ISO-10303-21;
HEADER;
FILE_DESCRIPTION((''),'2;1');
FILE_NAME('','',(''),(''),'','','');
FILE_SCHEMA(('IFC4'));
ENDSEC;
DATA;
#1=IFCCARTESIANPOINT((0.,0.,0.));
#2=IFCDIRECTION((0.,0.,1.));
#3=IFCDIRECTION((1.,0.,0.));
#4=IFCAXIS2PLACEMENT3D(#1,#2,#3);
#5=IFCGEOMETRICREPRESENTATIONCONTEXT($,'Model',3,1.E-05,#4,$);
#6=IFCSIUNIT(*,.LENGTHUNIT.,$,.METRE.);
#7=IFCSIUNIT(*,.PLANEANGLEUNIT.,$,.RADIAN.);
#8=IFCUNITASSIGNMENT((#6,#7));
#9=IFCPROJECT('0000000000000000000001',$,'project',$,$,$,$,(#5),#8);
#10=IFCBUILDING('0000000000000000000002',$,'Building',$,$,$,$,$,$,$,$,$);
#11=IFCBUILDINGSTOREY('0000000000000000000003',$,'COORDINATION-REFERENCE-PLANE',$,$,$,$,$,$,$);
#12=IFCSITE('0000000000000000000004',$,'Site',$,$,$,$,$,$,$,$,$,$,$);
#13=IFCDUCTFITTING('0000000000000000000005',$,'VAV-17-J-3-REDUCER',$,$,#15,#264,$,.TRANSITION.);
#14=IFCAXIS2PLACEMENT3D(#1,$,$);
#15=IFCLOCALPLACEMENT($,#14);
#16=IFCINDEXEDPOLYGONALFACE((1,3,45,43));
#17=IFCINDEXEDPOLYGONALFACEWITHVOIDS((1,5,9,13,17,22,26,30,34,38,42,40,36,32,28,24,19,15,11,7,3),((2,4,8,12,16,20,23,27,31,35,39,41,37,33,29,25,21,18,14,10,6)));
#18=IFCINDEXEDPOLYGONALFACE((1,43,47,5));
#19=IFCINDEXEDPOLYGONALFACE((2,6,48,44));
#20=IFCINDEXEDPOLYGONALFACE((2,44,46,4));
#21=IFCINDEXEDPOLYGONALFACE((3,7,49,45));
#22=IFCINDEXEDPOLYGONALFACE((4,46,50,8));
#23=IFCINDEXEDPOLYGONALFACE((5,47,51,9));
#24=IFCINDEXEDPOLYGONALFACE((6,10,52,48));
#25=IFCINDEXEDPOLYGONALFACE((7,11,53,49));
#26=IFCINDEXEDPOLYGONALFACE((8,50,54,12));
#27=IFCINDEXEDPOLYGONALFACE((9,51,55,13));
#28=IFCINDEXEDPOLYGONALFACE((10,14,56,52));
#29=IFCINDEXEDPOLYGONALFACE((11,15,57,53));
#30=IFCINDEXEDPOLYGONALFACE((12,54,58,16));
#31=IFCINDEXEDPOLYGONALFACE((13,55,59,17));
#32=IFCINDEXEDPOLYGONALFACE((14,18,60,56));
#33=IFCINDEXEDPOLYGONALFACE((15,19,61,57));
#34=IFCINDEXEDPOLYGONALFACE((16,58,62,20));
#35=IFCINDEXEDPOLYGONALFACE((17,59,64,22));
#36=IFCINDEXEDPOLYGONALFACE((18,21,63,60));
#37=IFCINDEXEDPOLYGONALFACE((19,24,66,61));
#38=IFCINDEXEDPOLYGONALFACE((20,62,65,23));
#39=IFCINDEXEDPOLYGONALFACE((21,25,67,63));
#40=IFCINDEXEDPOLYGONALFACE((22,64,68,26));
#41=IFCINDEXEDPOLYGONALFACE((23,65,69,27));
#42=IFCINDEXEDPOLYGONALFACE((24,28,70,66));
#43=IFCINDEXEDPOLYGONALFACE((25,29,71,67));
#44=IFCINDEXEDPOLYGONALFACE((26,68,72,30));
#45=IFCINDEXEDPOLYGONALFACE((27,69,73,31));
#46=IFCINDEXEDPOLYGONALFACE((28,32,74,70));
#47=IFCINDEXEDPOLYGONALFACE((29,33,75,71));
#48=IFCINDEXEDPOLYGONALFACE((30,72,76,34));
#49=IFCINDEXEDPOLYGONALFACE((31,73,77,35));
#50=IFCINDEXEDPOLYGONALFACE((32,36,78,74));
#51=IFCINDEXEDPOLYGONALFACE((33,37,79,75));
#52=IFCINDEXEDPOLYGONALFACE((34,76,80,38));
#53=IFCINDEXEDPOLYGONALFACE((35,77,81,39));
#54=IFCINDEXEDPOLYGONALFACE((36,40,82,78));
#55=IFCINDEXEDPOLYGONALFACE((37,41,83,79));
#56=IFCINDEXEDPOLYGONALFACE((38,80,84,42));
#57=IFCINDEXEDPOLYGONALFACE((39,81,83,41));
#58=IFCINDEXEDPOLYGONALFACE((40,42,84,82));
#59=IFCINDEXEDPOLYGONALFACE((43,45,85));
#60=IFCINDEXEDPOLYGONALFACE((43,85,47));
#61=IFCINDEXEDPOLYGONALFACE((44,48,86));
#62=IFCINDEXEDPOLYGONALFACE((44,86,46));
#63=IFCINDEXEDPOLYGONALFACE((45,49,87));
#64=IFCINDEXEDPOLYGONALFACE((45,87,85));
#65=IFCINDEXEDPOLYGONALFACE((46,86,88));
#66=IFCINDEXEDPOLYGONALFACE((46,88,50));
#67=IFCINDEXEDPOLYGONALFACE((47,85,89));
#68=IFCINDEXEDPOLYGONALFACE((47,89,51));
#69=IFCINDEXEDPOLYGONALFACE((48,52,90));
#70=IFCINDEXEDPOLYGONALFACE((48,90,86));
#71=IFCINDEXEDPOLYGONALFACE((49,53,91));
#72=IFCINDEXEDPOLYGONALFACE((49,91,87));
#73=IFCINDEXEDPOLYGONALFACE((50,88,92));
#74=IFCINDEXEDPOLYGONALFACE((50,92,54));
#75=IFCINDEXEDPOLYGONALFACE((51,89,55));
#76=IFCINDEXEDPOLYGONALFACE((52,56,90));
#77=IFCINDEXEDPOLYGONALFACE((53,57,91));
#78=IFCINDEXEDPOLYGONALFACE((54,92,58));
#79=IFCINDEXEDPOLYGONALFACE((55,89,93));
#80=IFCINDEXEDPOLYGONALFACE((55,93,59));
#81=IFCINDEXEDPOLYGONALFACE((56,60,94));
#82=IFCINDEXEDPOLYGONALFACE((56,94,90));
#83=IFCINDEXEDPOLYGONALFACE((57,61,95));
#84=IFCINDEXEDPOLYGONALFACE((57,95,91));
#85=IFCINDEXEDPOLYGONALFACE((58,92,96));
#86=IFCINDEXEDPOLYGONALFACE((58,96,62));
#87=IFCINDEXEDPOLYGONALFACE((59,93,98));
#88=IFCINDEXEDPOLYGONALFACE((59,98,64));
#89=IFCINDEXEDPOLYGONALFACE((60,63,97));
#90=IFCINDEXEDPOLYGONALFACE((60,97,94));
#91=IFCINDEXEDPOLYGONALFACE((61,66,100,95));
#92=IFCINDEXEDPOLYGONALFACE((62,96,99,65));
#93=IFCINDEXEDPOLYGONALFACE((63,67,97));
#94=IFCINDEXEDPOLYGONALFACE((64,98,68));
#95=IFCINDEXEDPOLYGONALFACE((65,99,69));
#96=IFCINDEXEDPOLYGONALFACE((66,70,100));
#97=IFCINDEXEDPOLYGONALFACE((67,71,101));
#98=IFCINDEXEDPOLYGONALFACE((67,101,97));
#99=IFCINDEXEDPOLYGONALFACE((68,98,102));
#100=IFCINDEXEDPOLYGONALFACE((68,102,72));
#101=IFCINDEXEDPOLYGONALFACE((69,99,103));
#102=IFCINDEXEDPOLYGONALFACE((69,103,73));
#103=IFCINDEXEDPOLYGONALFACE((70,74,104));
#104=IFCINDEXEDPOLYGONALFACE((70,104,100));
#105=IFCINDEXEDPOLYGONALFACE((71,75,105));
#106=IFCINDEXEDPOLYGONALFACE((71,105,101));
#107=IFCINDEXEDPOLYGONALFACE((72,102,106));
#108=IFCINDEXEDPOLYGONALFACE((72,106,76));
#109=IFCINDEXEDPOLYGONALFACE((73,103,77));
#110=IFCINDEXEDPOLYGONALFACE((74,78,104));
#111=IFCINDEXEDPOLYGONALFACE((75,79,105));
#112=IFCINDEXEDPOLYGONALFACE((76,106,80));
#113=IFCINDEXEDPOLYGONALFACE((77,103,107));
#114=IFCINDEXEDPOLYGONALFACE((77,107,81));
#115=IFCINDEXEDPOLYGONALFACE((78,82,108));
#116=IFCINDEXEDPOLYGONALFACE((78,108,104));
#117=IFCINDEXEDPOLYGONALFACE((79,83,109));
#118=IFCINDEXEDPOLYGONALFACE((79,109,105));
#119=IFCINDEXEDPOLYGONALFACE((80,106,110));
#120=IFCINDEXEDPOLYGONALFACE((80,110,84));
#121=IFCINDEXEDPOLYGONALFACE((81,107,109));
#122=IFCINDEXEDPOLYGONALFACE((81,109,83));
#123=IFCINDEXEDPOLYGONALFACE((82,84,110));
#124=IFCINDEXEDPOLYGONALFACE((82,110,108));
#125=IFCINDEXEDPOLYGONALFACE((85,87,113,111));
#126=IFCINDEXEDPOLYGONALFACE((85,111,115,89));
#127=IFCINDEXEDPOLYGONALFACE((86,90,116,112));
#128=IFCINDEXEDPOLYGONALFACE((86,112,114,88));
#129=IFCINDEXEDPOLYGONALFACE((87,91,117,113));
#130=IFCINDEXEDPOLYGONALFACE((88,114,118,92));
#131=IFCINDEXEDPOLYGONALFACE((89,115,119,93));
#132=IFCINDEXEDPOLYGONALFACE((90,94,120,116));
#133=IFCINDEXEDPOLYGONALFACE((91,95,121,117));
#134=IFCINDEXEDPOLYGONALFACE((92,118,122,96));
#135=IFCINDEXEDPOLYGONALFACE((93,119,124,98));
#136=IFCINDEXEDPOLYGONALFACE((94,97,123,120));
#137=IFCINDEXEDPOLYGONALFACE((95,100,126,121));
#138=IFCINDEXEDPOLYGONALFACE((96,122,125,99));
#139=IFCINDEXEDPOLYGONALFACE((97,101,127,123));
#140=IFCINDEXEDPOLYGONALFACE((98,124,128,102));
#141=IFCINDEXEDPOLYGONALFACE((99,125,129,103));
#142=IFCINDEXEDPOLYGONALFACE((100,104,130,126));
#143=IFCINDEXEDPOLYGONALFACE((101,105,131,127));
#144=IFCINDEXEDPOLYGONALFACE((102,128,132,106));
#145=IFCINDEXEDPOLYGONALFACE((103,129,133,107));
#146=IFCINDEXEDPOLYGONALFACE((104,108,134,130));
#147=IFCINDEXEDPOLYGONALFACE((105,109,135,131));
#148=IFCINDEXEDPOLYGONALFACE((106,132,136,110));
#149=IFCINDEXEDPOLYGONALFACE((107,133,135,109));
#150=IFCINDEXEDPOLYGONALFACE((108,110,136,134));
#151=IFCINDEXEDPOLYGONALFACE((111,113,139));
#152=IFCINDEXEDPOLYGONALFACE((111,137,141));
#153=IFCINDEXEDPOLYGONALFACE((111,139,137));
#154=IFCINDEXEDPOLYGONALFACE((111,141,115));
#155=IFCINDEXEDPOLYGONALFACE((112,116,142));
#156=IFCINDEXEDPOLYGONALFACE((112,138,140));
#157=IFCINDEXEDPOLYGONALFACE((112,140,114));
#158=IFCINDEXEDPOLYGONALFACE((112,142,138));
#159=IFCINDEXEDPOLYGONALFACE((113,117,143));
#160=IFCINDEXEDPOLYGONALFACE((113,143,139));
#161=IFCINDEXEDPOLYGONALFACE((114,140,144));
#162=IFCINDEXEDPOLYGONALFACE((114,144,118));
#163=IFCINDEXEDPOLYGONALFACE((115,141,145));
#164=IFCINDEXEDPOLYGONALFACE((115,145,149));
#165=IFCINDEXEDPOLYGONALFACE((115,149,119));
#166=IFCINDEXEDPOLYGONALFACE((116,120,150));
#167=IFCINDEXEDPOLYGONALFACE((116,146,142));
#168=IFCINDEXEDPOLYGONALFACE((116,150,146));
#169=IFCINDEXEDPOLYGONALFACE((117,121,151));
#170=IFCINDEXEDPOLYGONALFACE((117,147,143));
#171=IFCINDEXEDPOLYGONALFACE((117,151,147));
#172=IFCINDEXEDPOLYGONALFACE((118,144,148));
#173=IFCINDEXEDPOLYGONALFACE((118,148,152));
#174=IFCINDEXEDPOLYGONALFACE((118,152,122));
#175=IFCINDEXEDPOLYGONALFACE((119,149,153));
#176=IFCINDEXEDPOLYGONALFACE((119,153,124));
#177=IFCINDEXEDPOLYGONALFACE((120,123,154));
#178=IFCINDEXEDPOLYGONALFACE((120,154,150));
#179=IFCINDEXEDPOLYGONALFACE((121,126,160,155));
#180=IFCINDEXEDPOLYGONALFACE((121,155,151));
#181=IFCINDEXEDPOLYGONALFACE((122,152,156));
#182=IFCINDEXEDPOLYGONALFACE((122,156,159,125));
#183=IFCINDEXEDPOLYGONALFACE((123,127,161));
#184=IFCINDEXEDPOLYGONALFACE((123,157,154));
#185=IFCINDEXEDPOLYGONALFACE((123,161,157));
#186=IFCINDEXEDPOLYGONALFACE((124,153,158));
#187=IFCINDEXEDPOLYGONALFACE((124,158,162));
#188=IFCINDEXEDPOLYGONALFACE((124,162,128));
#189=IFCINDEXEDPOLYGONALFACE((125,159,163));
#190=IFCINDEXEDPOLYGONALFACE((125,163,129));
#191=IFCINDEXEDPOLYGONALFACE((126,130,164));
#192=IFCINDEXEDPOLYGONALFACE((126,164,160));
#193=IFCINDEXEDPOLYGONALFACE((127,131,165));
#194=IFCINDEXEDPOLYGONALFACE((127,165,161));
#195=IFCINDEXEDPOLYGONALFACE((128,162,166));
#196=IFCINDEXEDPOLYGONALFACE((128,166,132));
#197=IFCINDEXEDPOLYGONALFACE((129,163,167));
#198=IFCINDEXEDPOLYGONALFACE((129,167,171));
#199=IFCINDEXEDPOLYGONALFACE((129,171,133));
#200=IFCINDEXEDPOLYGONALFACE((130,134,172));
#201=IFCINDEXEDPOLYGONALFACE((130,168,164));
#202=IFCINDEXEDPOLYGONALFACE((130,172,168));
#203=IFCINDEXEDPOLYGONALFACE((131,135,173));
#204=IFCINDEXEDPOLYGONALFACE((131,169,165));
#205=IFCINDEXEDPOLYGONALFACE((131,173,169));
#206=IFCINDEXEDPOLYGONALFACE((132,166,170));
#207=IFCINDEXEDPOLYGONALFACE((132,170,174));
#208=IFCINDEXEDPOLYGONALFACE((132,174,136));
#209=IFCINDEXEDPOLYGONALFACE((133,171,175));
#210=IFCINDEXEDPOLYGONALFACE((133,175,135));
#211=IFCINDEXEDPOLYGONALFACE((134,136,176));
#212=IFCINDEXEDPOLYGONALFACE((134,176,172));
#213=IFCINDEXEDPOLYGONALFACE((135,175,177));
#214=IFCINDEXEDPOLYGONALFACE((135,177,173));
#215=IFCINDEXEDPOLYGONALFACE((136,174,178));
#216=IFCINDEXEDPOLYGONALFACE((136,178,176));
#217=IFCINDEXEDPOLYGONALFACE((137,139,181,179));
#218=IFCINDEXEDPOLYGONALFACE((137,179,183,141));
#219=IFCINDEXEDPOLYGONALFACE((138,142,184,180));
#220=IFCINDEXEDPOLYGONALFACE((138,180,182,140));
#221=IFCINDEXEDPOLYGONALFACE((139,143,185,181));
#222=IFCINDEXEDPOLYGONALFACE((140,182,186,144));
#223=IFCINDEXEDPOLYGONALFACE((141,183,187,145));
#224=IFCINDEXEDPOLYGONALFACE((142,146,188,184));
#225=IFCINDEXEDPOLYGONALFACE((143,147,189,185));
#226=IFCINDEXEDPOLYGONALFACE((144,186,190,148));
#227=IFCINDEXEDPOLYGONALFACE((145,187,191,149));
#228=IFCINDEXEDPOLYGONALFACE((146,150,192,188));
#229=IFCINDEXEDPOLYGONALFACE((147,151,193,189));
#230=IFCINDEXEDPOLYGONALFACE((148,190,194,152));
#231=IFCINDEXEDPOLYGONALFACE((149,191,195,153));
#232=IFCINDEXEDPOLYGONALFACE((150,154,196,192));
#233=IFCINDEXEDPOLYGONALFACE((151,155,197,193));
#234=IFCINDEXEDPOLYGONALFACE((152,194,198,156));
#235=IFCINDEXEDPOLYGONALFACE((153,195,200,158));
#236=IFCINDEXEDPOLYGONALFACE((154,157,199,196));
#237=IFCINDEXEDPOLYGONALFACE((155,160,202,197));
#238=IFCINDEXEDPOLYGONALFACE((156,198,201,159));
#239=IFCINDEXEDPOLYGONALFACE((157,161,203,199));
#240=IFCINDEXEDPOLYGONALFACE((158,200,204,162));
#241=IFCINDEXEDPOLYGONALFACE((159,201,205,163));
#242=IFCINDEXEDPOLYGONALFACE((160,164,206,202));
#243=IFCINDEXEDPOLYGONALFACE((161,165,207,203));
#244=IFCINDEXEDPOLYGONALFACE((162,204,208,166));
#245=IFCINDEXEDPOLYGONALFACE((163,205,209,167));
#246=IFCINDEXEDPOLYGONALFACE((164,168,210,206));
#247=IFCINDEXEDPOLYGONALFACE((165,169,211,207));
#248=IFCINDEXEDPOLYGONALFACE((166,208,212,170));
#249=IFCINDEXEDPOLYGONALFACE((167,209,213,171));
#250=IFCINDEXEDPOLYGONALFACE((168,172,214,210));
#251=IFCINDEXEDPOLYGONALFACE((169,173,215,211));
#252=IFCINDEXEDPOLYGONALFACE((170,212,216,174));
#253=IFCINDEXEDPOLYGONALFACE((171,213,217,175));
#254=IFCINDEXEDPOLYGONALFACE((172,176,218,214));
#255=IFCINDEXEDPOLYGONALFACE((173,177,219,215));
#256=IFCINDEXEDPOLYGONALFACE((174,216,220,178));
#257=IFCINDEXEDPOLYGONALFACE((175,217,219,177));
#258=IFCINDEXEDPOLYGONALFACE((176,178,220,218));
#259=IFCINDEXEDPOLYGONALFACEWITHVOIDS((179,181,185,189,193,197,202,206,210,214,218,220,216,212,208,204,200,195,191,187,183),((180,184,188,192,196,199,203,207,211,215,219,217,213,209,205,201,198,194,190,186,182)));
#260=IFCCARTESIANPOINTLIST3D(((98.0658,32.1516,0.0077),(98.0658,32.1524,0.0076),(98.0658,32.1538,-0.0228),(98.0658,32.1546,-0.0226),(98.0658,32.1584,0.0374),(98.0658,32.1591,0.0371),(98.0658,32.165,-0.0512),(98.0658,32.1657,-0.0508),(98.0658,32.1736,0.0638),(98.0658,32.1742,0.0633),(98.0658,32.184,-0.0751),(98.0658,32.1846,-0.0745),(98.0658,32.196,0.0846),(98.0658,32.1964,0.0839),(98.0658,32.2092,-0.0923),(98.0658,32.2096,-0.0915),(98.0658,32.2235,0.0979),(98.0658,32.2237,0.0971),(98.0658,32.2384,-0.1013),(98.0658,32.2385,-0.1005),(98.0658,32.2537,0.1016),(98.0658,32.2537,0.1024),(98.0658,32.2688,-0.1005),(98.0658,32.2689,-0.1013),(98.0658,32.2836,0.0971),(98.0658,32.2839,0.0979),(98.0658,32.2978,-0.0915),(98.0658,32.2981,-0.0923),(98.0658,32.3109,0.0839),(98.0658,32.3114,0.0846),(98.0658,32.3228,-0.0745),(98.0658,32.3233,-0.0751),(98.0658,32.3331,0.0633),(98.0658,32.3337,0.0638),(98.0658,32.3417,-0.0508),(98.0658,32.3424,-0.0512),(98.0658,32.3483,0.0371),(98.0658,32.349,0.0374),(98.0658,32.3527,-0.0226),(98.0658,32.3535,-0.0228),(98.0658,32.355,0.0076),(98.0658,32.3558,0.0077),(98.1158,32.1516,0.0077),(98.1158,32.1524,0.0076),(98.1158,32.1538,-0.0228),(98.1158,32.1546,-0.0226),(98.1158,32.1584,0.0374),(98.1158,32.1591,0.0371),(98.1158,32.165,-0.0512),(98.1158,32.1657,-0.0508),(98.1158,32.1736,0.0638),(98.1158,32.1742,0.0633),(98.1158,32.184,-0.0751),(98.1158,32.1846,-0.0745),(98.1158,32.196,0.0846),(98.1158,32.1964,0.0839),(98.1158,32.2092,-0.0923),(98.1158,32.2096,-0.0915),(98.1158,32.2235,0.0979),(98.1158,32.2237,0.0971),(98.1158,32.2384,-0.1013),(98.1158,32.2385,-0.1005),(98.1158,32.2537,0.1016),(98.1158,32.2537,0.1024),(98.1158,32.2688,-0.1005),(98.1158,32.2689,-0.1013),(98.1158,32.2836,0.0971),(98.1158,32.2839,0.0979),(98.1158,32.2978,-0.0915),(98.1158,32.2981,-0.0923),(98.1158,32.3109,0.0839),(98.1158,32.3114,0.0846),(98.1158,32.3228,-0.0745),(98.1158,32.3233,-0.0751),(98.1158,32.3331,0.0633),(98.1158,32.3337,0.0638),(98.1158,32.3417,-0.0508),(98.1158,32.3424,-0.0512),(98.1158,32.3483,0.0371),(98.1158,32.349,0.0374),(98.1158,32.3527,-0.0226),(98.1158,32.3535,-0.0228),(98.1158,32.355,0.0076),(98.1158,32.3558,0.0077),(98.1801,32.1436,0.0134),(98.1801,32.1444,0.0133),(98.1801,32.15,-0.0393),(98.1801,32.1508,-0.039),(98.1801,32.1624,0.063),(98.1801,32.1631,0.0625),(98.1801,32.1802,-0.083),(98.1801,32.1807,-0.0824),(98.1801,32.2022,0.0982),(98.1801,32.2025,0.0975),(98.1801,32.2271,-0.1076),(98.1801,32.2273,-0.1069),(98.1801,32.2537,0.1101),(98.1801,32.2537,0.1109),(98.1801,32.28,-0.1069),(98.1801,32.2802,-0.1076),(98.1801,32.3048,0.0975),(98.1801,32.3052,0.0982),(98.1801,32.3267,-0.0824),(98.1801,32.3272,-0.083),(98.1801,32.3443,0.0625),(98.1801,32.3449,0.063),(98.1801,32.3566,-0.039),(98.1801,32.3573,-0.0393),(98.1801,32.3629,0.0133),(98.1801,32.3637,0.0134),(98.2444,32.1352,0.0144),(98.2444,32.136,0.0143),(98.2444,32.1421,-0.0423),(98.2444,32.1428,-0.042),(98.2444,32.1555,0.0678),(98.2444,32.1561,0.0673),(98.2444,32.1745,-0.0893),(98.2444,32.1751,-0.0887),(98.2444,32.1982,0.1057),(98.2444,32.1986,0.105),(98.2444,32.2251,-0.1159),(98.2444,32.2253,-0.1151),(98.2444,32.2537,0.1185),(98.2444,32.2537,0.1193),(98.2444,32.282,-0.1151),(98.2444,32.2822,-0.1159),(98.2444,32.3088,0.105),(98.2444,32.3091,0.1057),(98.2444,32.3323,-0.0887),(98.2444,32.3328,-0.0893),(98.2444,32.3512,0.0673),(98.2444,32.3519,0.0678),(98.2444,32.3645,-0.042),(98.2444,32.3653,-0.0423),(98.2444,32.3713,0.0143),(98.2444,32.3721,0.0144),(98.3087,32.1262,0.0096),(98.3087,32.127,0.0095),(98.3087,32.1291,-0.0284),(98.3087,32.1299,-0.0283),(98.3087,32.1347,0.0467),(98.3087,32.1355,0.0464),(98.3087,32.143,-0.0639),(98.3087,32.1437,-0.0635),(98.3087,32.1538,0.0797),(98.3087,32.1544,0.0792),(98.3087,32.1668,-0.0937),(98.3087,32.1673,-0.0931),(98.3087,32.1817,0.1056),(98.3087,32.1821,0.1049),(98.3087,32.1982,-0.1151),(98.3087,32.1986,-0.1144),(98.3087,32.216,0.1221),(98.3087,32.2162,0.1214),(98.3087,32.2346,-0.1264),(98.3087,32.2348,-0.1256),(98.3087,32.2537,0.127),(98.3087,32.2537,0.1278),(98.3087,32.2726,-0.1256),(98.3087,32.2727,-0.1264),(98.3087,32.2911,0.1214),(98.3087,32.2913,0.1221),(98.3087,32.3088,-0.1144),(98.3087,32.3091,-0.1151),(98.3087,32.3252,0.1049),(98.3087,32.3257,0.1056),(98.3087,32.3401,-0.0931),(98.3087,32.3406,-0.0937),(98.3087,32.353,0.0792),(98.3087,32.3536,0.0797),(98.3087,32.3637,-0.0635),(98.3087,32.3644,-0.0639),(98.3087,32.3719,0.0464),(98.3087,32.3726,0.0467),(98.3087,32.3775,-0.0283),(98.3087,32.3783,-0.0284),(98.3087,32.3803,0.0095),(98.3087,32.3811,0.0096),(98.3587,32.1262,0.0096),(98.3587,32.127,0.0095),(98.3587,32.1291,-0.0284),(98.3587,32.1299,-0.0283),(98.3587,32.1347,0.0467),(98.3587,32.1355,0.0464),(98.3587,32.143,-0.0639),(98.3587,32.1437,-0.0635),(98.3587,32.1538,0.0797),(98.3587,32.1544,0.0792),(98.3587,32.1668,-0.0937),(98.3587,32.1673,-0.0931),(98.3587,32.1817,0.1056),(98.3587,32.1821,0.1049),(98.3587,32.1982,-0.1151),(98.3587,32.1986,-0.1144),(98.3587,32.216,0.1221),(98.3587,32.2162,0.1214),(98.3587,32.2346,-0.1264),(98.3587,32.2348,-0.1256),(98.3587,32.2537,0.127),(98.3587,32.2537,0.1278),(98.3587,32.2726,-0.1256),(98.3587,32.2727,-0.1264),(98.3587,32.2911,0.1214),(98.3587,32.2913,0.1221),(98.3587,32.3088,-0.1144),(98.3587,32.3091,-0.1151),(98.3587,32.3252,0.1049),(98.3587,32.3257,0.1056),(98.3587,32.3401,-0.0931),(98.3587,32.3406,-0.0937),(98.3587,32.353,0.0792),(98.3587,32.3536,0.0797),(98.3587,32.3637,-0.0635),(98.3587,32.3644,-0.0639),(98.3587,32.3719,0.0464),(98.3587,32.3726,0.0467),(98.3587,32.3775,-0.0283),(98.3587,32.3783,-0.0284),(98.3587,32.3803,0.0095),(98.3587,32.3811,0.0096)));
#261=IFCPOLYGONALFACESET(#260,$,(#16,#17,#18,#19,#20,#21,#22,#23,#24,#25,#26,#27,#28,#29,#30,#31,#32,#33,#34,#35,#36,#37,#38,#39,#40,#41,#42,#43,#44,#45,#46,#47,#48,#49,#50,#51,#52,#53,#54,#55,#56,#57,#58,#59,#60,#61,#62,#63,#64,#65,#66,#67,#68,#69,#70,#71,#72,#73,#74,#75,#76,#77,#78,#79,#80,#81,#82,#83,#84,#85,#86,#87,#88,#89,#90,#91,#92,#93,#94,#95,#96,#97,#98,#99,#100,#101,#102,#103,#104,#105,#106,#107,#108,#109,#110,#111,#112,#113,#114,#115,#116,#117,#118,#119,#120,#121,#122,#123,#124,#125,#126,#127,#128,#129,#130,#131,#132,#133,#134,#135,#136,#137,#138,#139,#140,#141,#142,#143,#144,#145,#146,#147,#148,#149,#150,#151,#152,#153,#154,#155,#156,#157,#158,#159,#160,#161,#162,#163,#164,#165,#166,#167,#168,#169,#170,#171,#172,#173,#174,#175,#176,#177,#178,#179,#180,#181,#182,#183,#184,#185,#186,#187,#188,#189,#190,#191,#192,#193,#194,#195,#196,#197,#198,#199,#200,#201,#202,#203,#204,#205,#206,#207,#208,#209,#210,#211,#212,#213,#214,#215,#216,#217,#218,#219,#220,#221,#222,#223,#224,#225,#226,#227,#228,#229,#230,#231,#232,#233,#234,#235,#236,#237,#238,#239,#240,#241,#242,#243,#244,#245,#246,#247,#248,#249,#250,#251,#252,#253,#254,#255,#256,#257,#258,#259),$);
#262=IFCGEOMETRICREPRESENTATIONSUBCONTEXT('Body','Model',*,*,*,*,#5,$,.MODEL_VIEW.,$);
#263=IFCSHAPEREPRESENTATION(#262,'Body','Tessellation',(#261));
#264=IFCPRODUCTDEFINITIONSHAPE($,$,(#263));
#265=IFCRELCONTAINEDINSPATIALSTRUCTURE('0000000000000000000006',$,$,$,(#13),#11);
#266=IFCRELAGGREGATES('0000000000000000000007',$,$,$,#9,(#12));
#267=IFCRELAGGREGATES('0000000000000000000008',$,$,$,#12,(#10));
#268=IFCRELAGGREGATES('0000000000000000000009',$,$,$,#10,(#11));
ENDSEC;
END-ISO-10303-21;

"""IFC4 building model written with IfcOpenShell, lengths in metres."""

from ifc_helpers import new_model, entity, si_unit, frame, origin_with_axes, place, context, subcontext, project, spatial, element, save


model = new_model("IFC4")

# Units and contexts
model_context = context("Model", 3, precision=1e-05, world=origin_with_axes())
body_context_1 = subcontext(model_context, "Body", "Model", "MODEL_VIEW")
ifc_project = project(units=[si_unit("LENGTHUNIT", "METRE"), si_unit("PLANEANGLEUNIT", "RADIAN")], contexts=[model_context])

# Site, building, storey
site = spatial("IfcSite", under=ifc_project, Name="Site")
building = spatial("IfcBuilding", under=site, Name="Building")
storey = spatial("IfcBuildingStorey", under=building, Name="COORDINATION-REFERENCE-PLANE")

# Duct fitting
for number, where, z_axis, x_axis, name in (
    (1, (98.3587, 32.2537, 0.0), (0.0, -1.0, 0.0), (0.0, 0.0, 1.0), "VAV-17-J-3-REDUCER"),
):
    element("IfcDuctFitting", number, at=place(None, frame(where, z_axis=z_axis, x_axis=x_axis)), inside=storey, Name=name, PredefinedType="TRANSITION", context=body_context_1, shape_type="SweptSolid", body=[
        entity("IfcRevolvedAreaSolid", entity("IfcArbitraryClosedProfileDef", "AREA", None, entity("IfcPolyline", [entity("IfcCartesianPoint", [0.1278, 0.0]), entity("IfcCartesianPoint", [0.1278, 0.05]), entity("IfcCartesianPoint", [0.1024, 0.2429]), entity("IfcCartesianPoint", [0.1024, 0.2929]), entity("IfcCartesianPoint", [0.1016, 0.2929]), entity("IfcCartesianPoint", [0.1016, 0.2429]), entity("IfcCartesianPoint", [0.127, 0.05]), entity("IfcCartesianPoint", [0.127, 0.0]), entity("IfcCartesianPoint", [0.1278, 0.0])])), entity("IfcAxis2Placement3D", entity("IfcCartesianPoint", [0.0, 0.0, 0.0])), entity("IfcAxis1Placement", entity("IfcCartesianPoint", [0.0, 0.0, 0.0]), entity("IfcDirection", [0.0, 1.0, 0.0])), 6.283185),
    ])

save(model, "model.ifc")
